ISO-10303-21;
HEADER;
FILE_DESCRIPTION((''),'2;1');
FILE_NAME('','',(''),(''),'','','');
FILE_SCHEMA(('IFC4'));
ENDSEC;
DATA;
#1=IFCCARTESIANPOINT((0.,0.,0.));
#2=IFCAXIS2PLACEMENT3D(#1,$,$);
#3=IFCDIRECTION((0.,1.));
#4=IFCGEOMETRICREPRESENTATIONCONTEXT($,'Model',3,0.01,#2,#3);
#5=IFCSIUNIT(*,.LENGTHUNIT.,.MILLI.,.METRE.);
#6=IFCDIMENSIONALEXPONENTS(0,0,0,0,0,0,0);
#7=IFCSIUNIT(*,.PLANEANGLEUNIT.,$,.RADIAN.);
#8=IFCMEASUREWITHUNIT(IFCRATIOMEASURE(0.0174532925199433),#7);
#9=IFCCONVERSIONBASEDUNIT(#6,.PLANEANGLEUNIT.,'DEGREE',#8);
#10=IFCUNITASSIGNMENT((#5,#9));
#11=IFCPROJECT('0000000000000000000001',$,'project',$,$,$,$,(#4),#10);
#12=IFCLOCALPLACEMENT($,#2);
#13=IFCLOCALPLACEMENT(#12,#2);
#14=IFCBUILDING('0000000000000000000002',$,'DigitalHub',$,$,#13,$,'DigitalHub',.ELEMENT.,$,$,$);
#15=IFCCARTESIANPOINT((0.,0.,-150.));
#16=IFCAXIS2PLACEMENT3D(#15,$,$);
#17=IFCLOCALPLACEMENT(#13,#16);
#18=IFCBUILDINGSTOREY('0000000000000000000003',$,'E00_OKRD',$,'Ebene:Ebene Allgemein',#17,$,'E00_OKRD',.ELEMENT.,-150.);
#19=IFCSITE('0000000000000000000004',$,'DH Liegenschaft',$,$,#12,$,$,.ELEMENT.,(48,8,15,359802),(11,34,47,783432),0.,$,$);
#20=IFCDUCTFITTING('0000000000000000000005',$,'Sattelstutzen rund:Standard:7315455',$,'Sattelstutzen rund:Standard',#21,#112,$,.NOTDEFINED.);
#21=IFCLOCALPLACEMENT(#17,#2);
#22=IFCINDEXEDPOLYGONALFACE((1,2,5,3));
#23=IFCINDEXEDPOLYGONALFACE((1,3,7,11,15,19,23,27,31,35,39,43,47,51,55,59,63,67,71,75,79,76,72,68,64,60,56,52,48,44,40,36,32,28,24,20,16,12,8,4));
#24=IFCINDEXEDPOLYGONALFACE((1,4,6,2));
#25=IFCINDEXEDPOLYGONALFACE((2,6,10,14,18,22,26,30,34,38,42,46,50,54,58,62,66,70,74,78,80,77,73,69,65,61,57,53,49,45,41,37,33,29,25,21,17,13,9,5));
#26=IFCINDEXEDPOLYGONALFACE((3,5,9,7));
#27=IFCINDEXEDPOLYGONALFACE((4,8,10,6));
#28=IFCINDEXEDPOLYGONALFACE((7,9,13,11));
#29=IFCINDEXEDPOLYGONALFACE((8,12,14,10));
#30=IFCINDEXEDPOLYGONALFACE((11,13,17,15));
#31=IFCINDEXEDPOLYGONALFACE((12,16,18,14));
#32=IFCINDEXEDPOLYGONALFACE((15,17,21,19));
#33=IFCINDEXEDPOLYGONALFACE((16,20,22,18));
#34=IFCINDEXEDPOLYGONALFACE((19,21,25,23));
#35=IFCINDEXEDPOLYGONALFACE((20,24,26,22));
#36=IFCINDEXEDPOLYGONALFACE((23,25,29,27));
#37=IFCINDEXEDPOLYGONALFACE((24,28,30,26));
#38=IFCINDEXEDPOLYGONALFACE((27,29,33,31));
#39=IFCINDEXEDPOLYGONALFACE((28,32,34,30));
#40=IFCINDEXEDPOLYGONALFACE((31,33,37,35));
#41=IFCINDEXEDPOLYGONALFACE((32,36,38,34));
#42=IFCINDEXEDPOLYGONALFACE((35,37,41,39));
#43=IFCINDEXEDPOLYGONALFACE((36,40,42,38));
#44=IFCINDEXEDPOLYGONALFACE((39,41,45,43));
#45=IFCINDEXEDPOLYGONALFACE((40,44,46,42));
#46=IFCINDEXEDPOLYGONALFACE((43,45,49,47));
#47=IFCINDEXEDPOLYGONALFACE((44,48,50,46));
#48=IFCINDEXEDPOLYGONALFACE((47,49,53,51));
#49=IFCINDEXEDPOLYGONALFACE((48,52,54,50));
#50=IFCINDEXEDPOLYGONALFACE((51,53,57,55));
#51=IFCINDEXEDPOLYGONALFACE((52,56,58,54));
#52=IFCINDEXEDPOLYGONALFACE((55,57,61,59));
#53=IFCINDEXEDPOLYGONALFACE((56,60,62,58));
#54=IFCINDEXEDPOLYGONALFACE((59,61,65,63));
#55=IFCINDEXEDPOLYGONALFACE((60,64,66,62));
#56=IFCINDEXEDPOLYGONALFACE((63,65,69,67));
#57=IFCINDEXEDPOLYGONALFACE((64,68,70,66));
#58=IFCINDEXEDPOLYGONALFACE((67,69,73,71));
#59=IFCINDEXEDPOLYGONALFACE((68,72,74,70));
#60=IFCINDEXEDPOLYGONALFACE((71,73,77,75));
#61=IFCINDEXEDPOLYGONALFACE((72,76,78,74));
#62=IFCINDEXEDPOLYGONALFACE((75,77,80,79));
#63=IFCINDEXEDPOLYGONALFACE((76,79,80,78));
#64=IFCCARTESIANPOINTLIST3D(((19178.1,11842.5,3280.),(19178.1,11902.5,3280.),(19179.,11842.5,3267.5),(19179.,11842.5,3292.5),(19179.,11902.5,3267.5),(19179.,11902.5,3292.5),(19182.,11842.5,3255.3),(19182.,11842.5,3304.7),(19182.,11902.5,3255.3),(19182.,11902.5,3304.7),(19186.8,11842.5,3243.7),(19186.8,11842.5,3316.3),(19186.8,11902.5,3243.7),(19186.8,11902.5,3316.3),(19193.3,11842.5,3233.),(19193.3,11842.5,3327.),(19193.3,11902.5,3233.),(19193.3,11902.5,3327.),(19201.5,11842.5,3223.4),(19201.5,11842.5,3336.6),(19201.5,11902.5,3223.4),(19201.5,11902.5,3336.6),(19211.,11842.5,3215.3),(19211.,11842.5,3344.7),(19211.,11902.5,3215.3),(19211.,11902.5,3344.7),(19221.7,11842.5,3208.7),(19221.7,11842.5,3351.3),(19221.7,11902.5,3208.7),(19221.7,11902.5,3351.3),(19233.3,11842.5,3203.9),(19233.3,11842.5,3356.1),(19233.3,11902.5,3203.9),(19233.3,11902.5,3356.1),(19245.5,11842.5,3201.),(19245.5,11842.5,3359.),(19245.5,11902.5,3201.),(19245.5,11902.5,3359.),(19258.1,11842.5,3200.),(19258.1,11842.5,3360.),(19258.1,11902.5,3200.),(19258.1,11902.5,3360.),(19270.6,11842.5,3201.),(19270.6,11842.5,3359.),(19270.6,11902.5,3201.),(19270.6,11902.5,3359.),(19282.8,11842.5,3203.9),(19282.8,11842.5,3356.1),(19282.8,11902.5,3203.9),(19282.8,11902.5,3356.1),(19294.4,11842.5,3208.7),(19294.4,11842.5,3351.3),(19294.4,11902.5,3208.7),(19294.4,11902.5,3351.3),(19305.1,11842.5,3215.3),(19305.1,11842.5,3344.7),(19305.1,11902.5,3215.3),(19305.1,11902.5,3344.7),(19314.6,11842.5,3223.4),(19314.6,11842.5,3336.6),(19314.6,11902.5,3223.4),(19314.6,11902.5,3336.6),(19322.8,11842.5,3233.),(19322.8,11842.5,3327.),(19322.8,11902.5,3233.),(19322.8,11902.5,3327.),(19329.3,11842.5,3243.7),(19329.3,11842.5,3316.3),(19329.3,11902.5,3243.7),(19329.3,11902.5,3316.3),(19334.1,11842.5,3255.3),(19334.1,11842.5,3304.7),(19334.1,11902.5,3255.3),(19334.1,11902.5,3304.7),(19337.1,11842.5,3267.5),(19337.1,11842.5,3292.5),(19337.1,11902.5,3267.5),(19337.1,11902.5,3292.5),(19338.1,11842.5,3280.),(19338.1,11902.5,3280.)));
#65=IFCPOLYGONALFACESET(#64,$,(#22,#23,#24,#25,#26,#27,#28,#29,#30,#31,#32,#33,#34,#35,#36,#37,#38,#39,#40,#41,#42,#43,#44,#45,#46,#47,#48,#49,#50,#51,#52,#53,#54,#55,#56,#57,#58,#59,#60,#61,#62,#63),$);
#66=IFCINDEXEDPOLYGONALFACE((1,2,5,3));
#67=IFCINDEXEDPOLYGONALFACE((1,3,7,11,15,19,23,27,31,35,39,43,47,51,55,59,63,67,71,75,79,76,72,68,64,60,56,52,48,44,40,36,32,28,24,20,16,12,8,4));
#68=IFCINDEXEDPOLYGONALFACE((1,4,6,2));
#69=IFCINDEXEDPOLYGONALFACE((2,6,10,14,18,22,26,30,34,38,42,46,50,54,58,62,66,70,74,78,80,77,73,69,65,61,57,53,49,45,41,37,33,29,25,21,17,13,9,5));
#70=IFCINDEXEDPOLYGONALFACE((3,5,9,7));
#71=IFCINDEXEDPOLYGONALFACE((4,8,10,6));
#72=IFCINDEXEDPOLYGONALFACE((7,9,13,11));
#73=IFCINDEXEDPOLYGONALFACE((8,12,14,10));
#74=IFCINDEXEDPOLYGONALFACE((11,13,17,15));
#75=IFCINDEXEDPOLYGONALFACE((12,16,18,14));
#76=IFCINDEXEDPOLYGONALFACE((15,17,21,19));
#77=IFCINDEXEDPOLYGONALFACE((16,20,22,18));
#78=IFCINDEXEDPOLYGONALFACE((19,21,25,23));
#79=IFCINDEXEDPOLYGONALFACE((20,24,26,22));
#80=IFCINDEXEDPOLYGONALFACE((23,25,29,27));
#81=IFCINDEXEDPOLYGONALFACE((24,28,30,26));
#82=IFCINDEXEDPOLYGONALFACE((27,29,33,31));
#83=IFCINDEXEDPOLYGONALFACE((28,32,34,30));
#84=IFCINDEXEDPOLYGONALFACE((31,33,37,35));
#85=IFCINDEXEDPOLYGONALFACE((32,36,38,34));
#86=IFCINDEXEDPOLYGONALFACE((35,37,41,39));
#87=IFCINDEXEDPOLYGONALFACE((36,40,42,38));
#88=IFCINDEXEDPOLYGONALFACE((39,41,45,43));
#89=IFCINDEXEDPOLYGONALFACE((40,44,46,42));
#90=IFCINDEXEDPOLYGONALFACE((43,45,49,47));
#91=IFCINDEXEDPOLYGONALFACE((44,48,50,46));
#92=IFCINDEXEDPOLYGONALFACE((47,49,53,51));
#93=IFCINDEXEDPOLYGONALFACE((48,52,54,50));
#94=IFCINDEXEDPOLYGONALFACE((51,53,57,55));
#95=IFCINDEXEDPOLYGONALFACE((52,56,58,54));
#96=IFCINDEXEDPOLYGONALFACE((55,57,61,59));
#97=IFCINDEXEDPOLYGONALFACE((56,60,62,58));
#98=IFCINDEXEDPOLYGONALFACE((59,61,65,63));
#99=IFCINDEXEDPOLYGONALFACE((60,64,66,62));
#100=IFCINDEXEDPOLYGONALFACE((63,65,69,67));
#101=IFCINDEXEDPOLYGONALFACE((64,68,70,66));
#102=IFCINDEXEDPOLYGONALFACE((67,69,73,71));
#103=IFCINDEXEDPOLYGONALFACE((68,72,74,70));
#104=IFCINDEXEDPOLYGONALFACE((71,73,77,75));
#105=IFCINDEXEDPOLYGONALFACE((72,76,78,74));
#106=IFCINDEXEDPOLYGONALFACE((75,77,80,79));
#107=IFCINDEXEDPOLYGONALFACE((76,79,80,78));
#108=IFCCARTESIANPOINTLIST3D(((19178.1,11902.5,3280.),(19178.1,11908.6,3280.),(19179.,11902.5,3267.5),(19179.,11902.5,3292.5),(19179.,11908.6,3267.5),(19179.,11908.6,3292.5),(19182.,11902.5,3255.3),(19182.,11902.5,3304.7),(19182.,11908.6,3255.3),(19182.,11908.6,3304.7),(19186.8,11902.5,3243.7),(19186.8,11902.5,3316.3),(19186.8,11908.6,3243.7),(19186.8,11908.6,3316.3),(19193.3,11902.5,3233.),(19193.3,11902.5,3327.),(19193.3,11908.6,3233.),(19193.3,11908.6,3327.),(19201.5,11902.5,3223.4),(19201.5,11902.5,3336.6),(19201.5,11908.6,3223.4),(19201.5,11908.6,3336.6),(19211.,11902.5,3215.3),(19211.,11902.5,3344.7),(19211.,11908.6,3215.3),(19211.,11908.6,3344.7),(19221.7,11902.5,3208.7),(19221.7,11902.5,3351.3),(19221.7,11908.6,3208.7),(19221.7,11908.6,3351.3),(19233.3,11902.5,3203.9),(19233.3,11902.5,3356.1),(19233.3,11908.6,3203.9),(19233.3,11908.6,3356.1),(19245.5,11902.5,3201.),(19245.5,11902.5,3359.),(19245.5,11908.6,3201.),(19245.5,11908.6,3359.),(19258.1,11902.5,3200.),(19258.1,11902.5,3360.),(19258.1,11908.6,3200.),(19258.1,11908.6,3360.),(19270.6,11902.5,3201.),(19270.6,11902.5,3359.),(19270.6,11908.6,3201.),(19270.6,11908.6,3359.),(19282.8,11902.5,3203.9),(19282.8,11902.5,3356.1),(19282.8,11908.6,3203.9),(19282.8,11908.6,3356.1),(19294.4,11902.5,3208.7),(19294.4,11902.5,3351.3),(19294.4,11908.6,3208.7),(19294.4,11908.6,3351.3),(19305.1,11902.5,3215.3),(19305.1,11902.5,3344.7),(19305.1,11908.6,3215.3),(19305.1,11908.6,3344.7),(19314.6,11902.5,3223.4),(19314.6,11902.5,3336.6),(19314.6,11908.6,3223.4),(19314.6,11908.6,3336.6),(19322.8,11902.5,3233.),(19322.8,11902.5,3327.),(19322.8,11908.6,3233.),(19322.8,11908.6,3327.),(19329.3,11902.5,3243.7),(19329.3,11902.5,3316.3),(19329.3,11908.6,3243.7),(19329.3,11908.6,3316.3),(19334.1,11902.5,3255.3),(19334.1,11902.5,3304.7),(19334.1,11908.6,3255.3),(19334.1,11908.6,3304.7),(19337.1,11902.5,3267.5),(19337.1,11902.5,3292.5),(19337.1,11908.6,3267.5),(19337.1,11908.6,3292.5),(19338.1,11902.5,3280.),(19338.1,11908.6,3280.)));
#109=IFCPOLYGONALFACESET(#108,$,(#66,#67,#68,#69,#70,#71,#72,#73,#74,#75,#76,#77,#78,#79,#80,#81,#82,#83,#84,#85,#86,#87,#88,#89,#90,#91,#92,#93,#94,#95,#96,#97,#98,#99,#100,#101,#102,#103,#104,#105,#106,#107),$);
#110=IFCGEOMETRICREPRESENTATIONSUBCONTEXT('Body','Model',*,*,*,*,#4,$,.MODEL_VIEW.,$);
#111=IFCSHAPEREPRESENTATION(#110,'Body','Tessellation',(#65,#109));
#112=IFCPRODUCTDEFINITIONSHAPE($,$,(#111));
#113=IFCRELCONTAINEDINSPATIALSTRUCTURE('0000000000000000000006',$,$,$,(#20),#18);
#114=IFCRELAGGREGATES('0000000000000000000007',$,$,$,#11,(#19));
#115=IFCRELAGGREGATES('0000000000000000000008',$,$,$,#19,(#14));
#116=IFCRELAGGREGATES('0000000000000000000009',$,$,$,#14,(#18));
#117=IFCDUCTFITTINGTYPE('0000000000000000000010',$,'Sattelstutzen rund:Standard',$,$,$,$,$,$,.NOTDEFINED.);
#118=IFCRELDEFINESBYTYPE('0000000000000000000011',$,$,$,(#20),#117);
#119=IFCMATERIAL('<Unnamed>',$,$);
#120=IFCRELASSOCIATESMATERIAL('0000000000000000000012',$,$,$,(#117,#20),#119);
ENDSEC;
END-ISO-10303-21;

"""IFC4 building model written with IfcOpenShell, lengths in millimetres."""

from ifc_helpers import new_model, entity, si_unit, converted_unit, direction, frame, origin, place, context, subcontext, project, spatial, indexed_curve, outline, extrude, source, transform, mapped, material, type_object, type_shapes, element, save


model = new_model("IFC4")

# Units and contexts
model_context = context("Model", 3, precision=0.01, world=origin(), true_north=direction((0.0, 1.0)))
body_context = subcontext(model_context, "Body", "Model", "MODEL_VIEW")
ifc_project = project(units=[si_unit("LENGTHUNIT", "METRE", prefix="MILLI"), converted_unit("PLANEANGLEUNIT", "DEGREE", entity("IfcRatioMeasure", 0.0174532925199433), si_unit("PLANEANGLEUNIT", "RADIAN"), dimensions=[0, 0, 0, 0, 0, 0, 0])], contexts=[model_context])

# Site, building, storey
site_placement = place(None, origin())
site = spatial("IfcSite", under=ifc_project, at=site_placement, Name="DH Liegenschaft", CompositionType="ELEMENT", RefLatitude=(48, 8, 15, 359802), RefLongitude=(11, 34, 47, 783432), RefElevation=0.0)
building_placement = place(site_placement, origin())
building = spatial("IfcBuilding", under=site, at=building_placement, Name="DigitalHub", LongName="DigitalHub", CompositionType="ELEMENT")
storey_placement = place(building_placement, frame((0.0, 0.0, -150.0)))
storey = spatial("IfcBuildingStorey", under=building, at=storey_placement, Name="E00_OKRD", ObjectType="Ebene:Ebene Allgemein", LongName="E00_OKRD", CompositionType="ELEMENT", Elevation=-150.0)

# Shared definitions
ifc_material_1 = material(Name="<Unnamed>")

# Duct fitting
duct_fitting_type_1 = type_object("IfcDuctFittingType", Name="Sattelstutzen rund:Standard", PredefinedType="NOTDEFINED", material=ifc_material_1)
shared_shape_1 = source(origin(), body_context, "Body", "SweptSolid", [
    extrude(outline(indexed_curve([(0.0, 80.0), (-12.5, 79.0), (-24.7, 76.1), (-36.3, 71.3), (-47.0, 64.7), (-56.6, 56.6), (-64.7, 47.0), (-71.3, 36.3), (-76.1, 24.7), (-79.0, 12.5), (-80.0, 0.0), (-79.0, -12.5), (-76.1, -24.7), (-71.3, -36.3), (-64.7, -47.0), (-56.6, -56.6), (-47.0, -64.7), (-36.3, -71.3), (-24.7, -76.1), (-12.5, -79.0), (0.0, -80.0), (12.5, -79.0), (24.7, -76.1), (36.3, -71.3), (47.0, -64.7), (56.6, -56.6), (64.7, -47.0), (71.3, -36.3), (76.1, -24.7), (79.0, -12.5), (80.0, 0.0), (79.0, 12.5), (76.1, 24.7), (71.3, 36.3), (64.7, 47.0), (56.6, 56.6), (47.0, 64.7), (36.3, 71.3), (24.7, 76.1), (12.5, 79.0), (0.0, 80.0)], self_intersect=False)), frame((0.0, 0.0, 0.0), z_axis=(1.0, 0.0, 0.0), x_axis=(0.0, 1.0, 0.0)), (0.0, 0.0, 1.0), 60.0),
    extrude(outline(indexed_curve([(0.0, 80.0), (-12.5, 79.0), (-24.7, 76.1), (-36.3, 71.3), (-47.0, 64.7), (-56.6, 56.6), (-64.7, 47.0), (-71.3, 36.3), (-76.1, 24.7), (-79.0, 12.5), (-80.0, 0.0), (-79.0, -12.5), (-76.1, -24.7), (-71.3, -36.3), (-64.7, -47.0), (-56.6, -56.6), (-47.0, -64.7), (-36.3, -71.3), (-24.7, -76.1), (-12.5, -79.0), (0.0, -80.0), (12.5, -79.0), (24.7, -76.1), (36.3, -71.3), (47.0, -64.7), (56.6, -56.6), (64.7, -47.0), (71.3, -36.3), (76.1, -24.7), (79.0, -12.5), (80.0, 0.0), (79.0, 12.5), (76.1, 24.7), (71.3, 36.3), (64.7, 47.0), (56.6, 56.6), (47.0, 64.7), (36.3, 71.3), (24.7, 76.1), (12.5, 79.0), (0.0, 80.0)], self_intersect=False)), frame((-6.1, 0.0, 0.0), z_axis=(1.0, 0.0, 0.0), x_axis=(0.0, 1.0, 0.0)), (0.0, 0.0, 1.0), 6.1),
])
type_shapes(duct_fitting_type_1, [shared_shape_1])
for number, where, z_axis, x_axis, name in (
    (1, (19258.1, 11902.5, 3280.0), (0.0, 0.0, -1.0), (0.0, -1.0, 0.0), "Sattelstutzen rund:Standard:7315455"),
):
    element("IfcDuctFitting", number, at=place(storey_placement, frame(where, z_axis=z_axis, x_axis=x_axis)), inside=storey, type_object=duct_fitting_type_1, material=ifc_material_1, Name=name, ObjectType="Sattelstutzen rund:Standard", PredefinedType="NOTDEFINED", context=body_context, shape_type="MappedRepresentation", body=[
        mapped(shared_shape_1, transform((0.0, 0.0, 0.0), scale=1.0)),
    ])

save(model, "model.ifc")
